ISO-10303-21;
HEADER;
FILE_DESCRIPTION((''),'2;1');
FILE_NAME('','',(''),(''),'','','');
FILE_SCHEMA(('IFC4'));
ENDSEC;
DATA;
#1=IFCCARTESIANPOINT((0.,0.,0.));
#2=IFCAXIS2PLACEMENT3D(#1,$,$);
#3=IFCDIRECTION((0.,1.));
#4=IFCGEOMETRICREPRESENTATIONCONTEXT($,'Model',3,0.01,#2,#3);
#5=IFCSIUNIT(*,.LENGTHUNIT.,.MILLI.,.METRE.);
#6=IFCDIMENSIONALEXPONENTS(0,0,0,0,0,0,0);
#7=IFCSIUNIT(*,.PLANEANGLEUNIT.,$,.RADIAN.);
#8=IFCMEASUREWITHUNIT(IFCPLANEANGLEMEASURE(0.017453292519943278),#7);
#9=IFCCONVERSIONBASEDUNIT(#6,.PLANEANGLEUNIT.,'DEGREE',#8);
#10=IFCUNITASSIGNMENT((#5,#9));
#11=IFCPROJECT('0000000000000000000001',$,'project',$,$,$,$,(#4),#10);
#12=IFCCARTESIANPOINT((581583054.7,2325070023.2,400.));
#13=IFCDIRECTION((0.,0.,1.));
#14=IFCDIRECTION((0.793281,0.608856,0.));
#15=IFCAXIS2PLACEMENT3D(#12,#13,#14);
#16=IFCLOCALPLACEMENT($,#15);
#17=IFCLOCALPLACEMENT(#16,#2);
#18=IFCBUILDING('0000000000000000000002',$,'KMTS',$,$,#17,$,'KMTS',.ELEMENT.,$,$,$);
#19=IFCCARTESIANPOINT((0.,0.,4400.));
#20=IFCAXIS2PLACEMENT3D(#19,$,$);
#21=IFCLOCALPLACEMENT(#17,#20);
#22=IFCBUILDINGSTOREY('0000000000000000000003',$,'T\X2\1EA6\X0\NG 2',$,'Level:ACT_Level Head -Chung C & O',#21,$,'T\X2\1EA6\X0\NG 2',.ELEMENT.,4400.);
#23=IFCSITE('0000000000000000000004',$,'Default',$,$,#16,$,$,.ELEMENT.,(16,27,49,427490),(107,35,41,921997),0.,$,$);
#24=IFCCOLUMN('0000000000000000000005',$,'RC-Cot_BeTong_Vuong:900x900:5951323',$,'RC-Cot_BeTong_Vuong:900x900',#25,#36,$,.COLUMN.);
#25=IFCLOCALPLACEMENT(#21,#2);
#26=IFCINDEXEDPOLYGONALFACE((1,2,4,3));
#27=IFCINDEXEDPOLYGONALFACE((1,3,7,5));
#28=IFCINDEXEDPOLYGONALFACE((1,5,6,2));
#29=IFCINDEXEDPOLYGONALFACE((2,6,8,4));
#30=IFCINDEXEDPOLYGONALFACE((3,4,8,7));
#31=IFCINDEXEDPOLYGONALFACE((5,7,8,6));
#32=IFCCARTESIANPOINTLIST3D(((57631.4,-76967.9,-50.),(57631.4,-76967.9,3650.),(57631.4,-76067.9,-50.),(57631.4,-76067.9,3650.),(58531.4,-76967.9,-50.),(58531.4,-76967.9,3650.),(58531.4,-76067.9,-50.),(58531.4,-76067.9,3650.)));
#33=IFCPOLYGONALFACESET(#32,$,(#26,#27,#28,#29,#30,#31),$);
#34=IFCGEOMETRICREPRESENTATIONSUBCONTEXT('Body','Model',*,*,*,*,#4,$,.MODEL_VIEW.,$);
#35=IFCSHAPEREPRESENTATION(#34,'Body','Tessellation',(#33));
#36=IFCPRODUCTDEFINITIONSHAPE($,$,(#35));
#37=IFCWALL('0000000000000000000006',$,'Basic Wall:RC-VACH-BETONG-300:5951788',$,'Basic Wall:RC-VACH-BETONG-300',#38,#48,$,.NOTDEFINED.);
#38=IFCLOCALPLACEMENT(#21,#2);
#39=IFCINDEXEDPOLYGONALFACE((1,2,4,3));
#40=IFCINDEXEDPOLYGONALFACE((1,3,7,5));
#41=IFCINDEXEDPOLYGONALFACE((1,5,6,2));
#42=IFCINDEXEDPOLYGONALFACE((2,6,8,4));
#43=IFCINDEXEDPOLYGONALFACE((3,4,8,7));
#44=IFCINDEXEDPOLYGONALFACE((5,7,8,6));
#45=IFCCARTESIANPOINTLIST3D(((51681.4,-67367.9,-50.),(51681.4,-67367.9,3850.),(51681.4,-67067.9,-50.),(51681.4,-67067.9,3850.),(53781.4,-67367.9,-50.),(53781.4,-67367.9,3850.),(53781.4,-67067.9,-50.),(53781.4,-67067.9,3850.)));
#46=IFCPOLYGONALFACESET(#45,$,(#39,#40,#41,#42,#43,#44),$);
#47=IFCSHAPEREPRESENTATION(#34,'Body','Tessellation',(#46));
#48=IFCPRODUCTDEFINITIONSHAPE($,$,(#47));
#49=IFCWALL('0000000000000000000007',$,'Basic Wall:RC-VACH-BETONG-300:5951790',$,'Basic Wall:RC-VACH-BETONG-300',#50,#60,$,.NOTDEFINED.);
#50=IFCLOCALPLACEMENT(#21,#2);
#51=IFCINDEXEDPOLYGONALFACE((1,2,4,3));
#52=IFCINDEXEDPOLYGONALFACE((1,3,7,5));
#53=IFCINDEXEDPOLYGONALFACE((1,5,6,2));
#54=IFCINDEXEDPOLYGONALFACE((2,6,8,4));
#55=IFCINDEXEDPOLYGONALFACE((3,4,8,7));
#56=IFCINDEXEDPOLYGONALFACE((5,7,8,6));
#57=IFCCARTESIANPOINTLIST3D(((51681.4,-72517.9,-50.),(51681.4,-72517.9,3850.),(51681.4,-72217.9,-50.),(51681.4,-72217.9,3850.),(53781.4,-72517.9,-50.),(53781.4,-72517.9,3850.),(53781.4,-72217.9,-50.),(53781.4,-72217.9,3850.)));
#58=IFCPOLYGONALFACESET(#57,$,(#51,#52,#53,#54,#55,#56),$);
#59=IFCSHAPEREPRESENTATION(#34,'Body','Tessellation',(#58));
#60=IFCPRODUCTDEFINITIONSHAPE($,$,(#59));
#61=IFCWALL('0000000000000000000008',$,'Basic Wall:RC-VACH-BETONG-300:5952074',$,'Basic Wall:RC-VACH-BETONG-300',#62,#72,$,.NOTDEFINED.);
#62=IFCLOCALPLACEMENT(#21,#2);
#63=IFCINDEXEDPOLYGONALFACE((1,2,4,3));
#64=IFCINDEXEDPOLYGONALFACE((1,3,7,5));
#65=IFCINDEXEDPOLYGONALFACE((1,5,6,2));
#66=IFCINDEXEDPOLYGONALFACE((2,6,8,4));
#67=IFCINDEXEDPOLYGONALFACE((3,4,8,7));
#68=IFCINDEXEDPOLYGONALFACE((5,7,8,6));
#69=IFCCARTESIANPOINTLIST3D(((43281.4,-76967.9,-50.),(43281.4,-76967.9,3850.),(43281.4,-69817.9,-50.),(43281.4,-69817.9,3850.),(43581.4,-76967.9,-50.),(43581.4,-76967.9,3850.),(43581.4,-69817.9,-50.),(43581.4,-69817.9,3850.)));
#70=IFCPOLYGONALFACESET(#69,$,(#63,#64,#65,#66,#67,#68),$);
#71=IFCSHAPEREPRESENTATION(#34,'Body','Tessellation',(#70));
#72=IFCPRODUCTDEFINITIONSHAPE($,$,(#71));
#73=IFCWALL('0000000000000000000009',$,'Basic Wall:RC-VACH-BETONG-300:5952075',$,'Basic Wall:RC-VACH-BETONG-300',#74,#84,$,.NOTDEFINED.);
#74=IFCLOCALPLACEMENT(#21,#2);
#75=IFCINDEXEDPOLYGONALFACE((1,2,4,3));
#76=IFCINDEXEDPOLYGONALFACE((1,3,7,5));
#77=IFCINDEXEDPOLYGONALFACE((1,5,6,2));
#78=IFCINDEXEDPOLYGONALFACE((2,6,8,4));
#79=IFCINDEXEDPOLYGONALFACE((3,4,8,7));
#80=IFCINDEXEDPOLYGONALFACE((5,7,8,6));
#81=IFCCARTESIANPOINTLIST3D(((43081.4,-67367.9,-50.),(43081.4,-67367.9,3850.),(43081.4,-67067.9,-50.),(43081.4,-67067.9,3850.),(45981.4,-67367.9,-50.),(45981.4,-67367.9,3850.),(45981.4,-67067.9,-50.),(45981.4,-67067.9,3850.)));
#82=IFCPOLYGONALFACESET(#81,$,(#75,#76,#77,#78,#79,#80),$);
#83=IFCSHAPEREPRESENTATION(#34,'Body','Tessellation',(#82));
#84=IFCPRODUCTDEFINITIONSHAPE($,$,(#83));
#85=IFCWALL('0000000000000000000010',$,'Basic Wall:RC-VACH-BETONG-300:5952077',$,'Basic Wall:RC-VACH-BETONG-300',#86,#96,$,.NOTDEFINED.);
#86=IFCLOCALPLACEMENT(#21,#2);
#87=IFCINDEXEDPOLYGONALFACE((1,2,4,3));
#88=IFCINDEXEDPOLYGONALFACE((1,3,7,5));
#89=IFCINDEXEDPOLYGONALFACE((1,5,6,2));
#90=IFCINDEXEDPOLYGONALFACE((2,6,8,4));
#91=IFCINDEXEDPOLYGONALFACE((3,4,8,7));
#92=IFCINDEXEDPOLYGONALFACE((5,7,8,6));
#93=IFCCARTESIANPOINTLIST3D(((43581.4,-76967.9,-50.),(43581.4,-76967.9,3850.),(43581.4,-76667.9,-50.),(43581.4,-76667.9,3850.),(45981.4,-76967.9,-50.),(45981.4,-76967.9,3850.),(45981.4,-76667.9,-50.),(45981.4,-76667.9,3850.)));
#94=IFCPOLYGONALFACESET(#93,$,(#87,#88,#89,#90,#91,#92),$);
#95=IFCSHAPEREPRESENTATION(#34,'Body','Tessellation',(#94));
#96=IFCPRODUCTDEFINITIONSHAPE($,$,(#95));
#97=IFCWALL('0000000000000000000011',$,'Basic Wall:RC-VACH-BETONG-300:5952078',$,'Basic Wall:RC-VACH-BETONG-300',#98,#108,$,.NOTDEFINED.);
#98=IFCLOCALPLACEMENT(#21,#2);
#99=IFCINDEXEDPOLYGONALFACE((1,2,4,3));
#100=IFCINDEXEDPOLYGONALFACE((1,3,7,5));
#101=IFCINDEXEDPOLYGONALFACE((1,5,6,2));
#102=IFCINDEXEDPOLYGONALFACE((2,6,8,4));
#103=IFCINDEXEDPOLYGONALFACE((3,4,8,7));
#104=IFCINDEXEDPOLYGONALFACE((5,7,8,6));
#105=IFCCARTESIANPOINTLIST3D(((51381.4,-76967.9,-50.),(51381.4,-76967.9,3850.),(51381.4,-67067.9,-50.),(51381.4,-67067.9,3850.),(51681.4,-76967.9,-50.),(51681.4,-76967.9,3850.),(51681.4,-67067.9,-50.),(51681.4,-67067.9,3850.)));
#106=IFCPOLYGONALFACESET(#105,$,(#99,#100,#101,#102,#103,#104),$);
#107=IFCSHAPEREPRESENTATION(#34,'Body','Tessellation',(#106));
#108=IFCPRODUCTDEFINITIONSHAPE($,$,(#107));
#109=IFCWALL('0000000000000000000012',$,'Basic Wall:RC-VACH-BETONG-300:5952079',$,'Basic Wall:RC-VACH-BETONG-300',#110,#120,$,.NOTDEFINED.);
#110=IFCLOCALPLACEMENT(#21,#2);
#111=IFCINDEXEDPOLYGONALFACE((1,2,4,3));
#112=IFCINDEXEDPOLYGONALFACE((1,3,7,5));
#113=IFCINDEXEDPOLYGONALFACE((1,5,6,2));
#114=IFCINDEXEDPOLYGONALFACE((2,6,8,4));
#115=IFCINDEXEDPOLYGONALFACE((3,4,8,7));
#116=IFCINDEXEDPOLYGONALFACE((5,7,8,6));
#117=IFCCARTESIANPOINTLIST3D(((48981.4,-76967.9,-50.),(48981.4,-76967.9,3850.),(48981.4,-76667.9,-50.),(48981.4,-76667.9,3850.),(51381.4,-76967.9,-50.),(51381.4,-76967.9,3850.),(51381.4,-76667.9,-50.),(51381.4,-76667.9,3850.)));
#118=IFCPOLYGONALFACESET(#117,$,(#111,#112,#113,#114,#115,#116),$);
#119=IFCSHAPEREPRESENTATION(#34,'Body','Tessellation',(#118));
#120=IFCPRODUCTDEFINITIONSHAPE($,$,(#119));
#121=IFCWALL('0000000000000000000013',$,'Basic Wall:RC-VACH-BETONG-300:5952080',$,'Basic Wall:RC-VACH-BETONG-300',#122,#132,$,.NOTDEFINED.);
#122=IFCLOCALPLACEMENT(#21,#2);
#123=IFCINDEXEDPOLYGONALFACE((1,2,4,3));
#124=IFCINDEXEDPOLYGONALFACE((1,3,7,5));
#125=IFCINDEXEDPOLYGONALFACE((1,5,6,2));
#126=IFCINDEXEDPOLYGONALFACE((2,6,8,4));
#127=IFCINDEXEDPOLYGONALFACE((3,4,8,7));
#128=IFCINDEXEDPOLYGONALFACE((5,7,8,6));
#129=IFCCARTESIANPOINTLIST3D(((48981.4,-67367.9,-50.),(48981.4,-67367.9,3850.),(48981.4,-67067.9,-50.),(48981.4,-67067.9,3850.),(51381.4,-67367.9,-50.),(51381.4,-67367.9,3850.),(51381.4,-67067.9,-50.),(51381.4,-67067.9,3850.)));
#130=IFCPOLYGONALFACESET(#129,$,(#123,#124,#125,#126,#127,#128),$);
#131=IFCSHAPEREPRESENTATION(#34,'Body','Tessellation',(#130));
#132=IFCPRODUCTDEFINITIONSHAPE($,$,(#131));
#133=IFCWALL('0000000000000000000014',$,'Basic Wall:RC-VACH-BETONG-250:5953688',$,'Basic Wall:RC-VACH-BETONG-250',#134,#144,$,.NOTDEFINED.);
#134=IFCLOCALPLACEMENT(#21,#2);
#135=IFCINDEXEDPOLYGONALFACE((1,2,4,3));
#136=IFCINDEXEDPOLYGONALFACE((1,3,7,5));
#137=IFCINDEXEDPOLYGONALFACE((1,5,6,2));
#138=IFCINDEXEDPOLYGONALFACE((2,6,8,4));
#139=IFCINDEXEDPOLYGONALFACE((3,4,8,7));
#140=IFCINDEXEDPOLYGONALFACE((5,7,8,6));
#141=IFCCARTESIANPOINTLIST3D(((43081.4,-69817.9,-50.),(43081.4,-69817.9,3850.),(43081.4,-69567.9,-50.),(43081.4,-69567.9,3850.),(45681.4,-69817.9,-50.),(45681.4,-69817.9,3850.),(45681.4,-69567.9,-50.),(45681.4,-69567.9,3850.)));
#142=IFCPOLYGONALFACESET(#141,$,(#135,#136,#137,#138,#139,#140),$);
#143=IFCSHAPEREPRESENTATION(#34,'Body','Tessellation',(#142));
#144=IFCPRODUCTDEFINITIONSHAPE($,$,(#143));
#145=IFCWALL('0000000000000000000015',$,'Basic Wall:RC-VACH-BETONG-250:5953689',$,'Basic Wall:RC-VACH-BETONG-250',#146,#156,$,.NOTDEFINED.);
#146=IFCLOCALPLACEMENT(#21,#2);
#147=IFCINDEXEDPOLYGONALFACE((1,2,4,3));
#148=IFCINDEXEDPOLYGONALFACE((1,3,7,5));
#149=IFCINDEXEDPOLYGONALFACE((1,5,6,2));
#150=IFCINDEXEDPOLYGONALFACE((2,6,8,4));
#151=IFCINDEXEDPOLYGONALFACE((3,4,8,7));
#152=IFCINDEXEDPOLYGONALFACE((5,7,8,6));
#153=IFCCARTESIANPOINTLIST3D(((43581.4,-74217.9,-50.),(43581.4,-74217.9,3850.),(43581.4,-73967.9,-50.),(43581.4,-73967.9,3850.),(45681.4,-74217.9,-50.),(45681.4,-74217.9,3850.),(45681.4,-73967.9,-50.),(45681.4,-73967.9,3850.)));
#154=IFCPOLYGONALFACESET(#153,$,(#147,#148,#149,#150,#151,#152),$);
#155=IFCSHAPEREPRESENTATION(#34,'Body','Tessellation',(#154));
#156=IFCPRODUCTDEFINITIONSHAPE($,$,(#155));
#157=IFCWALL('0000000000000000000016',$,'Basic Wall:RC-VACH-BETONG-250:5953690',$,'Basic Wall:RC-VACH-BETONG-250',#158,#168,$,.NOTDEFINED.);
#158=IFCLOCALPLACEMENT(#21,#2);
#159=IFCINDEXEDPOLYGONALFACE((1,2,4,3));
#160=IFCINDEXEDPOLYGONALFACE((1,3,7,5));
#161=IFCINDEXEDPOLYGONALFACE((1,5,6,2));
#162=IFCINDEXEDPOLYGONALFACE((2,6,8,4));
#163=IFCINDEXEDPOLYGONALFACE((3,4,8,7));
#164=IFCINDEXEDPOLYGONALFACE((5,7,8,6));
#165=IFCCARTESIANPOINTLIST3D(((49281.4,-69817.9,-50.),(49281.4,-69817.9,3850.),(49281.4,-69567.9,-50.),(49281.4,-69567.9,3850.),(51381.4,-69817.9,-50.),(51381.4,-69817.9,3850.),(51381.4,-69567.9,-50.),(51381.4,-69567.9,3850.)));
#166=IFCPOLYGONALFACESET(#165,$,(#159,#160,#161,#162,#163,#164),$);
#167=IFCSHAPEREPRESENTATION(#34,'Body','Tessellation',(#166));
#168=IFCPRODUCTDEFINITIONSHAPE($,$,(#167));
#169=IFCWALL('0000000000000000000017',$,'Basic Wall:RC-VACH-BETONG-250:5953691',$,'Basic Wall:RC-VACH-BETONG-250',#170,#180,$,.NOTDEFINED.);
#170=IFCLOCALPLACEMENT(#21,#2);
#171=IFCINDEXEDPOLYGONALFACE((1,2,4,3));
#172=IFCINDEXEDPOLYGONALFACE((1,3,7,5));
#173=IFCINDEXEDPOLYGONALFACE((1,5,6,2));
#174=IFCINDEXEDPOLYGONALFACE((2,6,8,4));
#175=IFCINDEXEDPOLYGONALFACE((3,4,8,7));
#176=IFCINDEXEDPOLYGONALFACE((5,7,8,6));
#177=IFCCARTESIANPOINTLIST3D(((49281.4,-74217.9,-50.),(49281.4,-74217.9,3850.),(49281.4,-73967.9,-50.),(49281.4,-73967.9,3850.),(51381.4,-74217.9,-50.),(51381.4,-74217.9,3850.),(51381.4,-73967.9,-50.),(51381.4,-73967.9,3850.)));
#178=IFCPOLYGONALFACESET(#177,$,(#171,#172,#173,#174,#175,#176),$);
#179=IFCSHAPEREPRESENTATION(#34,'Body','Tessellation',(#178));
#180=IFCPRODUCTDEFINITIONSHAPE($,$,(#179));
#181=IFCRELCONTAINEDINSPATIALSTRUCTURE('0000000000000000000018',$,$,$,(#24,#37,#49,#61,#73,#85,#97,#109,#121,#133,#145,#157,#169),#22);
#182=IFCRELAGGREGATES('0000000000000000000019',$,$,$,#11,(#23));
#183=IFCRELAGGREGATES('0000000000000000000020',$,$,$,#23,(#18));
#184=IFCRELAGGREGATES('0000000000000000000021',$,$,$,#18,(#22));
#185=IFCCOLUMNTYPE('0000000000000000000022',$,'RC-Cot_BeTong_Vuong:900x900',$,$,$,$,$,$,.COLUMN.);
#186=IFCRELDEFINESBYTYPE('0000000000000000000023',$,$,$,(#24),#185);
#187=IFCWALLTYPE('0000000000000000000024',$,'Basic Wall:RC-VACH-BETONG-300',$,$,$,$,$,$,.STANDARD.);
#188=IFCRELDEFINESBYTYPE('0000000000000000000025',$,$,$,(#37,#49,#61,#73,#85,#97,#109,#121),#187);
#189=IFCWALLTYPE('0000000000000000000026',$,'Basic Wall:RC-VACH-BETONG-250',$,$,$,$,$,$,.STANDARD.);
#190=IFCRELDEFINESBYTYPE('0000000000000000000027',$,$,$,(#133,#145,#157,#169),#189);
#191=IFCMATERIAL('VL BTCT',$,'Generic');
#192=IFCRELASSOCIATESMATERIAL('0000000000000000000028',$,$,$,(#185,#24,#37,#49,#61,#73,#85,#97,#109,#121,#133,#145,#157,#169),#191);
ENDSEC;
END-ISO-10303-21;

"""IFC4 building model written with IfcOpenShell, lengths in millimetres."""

from ifc_helpers import new_model, entity, si_unit, converted_unit, direction, frame, origin, place, context, subcontext, project, spatial, indexed_curve, outline, extrude, source, transform, mapped, material, type_object, type_shapes, element, save


model = new_model("IFC4")

# Units and contexts
model_context = context("Model", 3, precision=0.01, world=origin(), true_north=direction((0.0, 1.0)))
body_context = subcontext(model_context, "Body", "Model", "MODEL_VIEW")
ifc_project = project(units=[si_unit("LENGTHUNIT", "METRE", prefix="MILLI"), converted_unit("PLANEANGLEUNIT", "DEGREE", entity("IfcPlaneAngleMeasure", 0.017453292519943278), si_unit("PLANEANGLEUNIT", "RADIAN"), dimensions=[0, 0, 0, 0, 0, 0, 0])], contexts=[model_context])

# Site, building, storey
site_placement = place(None, frame((581583054.7, 2325070023.2, 400.0), z_axis=(0.0, 0.0, 1.0), x_axis=(0.793281, 0.608856, 0.0)))
site = spatial("IfcSite", under=ifc_project, at=site_placement, Name="Default", CompositionType="ELEMENT", RefLatitude=(16, 27, 49, 427490), RefLongitude=(107, 35, 41, 921997), RefElevation=0.0)
building_placement = place(site_placement, origin())
building = spatial("IfcBuilding", under=site, at=building_placement, Name="KMTS", LongName="KMTS", CompositionType="ELEMENT")
storey_placement = place(building_placement, frame((0.0, 0.0, 4400.0)))
storey = spatial("IfcBuildingStorey", under=building, at=storey_placement, Name="TẦNG 2", ObjectType="Level:ACT_Level Head -Chung C & O", LongName="TẦNG 2", CompositionType="ELEMENT", Elevation=4400.0)

# Column
ifc_material_1 = material(Name="VL BTCT", Category="Generic")
column_type_1 = type_object("IfcColumnType", Name="RC-Cot_BeTong_Vuong:900x900", PredefinedType="COLUMN", material=ifc_material_1)
shared_shape_1 = source(origin(), body_context, "Body", "SweptSolid", [
    extrude(outline(indexed_curve([(-450.0, -450.0), (450.0, -450.0), (450.0, 450.0), (-450.0, 450.0), (-450.0, -450.0)], self_intersect=False)), frame((58081.4, -76517.9, 4350.0), z_axis=(0.0, 0.0, 1.0), x_axis=(-1.0, 0.0, 0.0)), (0.0, 0.0, 1.0), 3700.0),
])
type_shapes(column_type_1, [shared_shape_1])
column_1_placement = place(storey_placement, frame((0.0, 0.0, -4400.0)))
element("IfcColumn", 1, at=column_1_placement, inside=storey, type_object=column_type_1, material=ifc_material_1, Name="RC-Cot_BeTong_Vuong:900x900:5951323", ObjectType="RC-Cot_BeTong_Vuong:900x900", PredefinedType="COLUMN", context=body_context, shape_type="MappedRepresentation", body=[
    mapped(shared_shape_1, transform((0.0, 0.0, 0.0), scale=1.0)),
])

# Walls
wall_type_1 = type_object("IfcWallType", Name="Basic Wall:RC-VACH-BETONG-300", PredefinedType="STANDARD")
wall_1_placement = place(storey_placement, frame((53781.4, -67217.9, -50.0), z_axis=(0.0, 0.0, 1.0), x_axis=(-1.0, 0.0, 0.0)))
element("IfcWall", 2, at=wall_1_placement, inside=storey, type_object=wall_type_1, material=ifc_material_1, Name="Basic Wall:RC-VACH-BETONG-300:5951788", ObjectType="Basic Wall:RC-VACH-BETONG-300", PredefinedType="NOTDEFINED", context=body_context, shape_type="SweptSolid", body=[
    extrude(outline(indexed_curve([(2100.0, 150.0), (0.0, 150.0), (0.0, -150.0), (2100.0, -150.0), (2100.0, 150.0)], self_intersect=False)), origin(), (0.0, 0.0, 1.0), 3900.0),
])
wall_2_placement = place(storey_placement, frame((53781.4, -72367.9, -50.0), z_axis=(0.0, 0.0, 1.0), x_axis=(-1.0, 0.0, 0.0)))
element("IfcWall", 3, at=wall_2_placement, inside=storey, type_object=wall_type_1, material=ifc_material_1, Name="Basic Wall:RC-VACH-BETONG-300:5951790", ObjectType="Basic Wall:RC-VACH-BETONG-300", PredefinedType="NOTDEFINED", context=body_context, shape_type="SweptSolid", body=[
    extrude(outline(indexed_curve([(2100.0, 150.0), (0.0, 150.0), (0.0, -150.0), (2100.0, -150.0), (2100.0, 150.0)], self_intersect=False)), origin(), (0.0, 0.0, 1.0), 3900.0),
])
wall_3_placement = place(storey_placement, frame((43431.4, -69817.9, -50.0), z_axis=(0.0, 0.0, 1.0), x_axis=(0.0, -1.0, 0.0)))
element("IfcWall", 4, at=wall_3_placement, inside=storey, type_object=wall_type_1, material=ifc_material_1, Name="Basic Wall:RC-VACH-BETONG-300:5952074", ObjectType="Basic Wall:RC-VACH-BETONG-300", PredefinedType="NOTDEFINED", context=body_context, shape_type="SweptSolid", body=[
    extrude(outline(indexed_curve([(7150.0, 150.0), (0.0, 150.0), (0.0, -150.0), (7150.0, -150.0), (7150.0, 150.0)], self_intersect=False)), origin(), (0.0, 0.0, 1.0), 3900.0),
])
wall_4_placement = place(storey_placement, frame((45981.4, -67217.9, -50.0), z_axis=(0.0, 0.0, 1.0), x_axis=(-1.0, 0.0, 0.0)))
element("IfcWall", 5, at=wall_4_placement, inside=storey, type_object=wall_type_1, material=ifc_material_1, Name="Basic Wall:RC-VACH-BETONG-300:5952075", ObjectType="Basic Wall:RC-VACH-BETONG-300", PredefinedType="NOTDEFINED", context=body_context, shape_type="SweptSolid", body=[
    extrude(outline(indexed_curve([(2900.0, 150.0), (0.0, 150.0), (0.0, -150.0), (2900.0, -150.0), (2900.0, 150.0)], self_intersect=False)), origin(), (0.0, 0.0, 1.0), 3900.0),
])
wall_5_placement = place(storey_placement, frame((45981.4, -76817.9, -50.0), z_axis=(0.0, 0.0, 1.0), x_axis=(-1.0, 0.0, 0.0)))
element("IfcWall", 6, at=wall_5_placement, inside=storey, type_object=wall_type_1, material=ifc_material_1, Name="Basic Wall:RC-VACH-BETONG-300:5952077", ObjectType="Basic Wall:RC-VACH-BETONG-300", PredefinedType="NOTDEFINED", context=body_context, shape_type="SweptSolid", body=[
    extrude(outline(indexed_curve([(2400.0, 150.0), (0.0, 150.0), (0.0, -150.0), (2400.0, -150.0), (2400.0, 150.0)], self_intersect=False)), origin(), (0.0, 0.0, 1.0), 3900.0),
])
wall_6_placement = place(storey_placement, frame((51531.4, -67067.9, -50.0), z_axis=(0.0, 0.0, 1.0), x_axis=(0.0, -1.0, 0.0)))
element("IfcWall", 7, at=wall_6_placement, inside=storey, type_object=wall_type_1, material=ifc_material_1, Name="Basic Wall:RC-VACH-BETONG-300:5952078", ObjectType="Basic Wall:RC-VACH-BETONG-300", PredefinedType="NOTDEFINED", context=body_context, shape_type="SweptSolid", body=[
    extrude(outline(indexed_curve([(9900.0, 150.0), (0.0, 150.0), (0.0, -150.0), (9900.0, -150.0), (9900.0, 150.0)], self_intersect=False)), origin(), (0.0, 0.0, 1.0), 3900.0),
])
wall_7_placement = place(storey_placement, frame((51381.4, -76817.9, -50.0), z_axis=(0.0, 0.0, 1.0), x_axis=(-1.0, 0.0, 0.0)))
element("IfcWall", 8, at=wall_7_placement, inside=storey, type_object=wall_type_1, material=ifc_material_1, Name="Basic Wall:RC-VACH-BETONG-300:5952079", ObjectType="Basic Wall:RC-VACH-BETONG-300", PredefinedType="NOTDEFINED", context=body_context, shape_type="SweptSolid", body=[
    extrude(outline(indexed_curve([(2400.0, 150.0), (0.0, 150.0), (0.0, -150.0), (2400.0, -150.0), (2400.0, 150.0)], self_intersect=False)), origin(), (0.0, 0.0, 1.0), 3900.0),
])
wall_8_placement = place(storey_placement, frame((51381.4, -67217.9, -50.0), z_axis=(0.0, 0.0, 1.0), x_axis=(-1.0, 0.0, 0.0)))
element("IfcWall", 9, at=wall_8_placement, inside=storey, type_object=wall_type_1, material=ifc_material_1, Name="Basic Wall:RC-VACH-BETONG-300:5952080", ObjectType="Basic Wall:RC-VACH-BETONG-300", PredefinedType="NOTDEFINED", context=body_context, shape_type="SweptSolid", body=[
    extrude(outline(indexed_curve([(2400.0, 150.0), (0.0, 150.0), (0.0, -150.0), (2400.0, -150.0), (2400.0, 150.0)], self_intersect=False)), origin(), (0.0, 0.0, 1.0), 3900.0),
])
wall_type_2 = type_object("IfcWallType", Name="Basic Wall:RC-VACH-BETONG-250", PredefinedType="STANDARD")
wall_9_placement = place(storey_placement, frame((45681.4, -69692.9, -50.0), z_axis=(0.0, 0.0, 1.0), x_axis=(-1.0, 0.0, 0.0)))
element("IfcWall", 10, at=wall_9_placement, inside=storey, type_object=wall_type_2, material=ifc_material_1, Name="Basic Wall:RC-VACH-BETONG-250:5953688", ObjectType="Basic Wall:RC-VACH-BETONG-250", PredefinedType="NOTDEFINED", context=body_context, shape_type="SweptSolid", body=[
    extrude(outline(indexed_curve([(2600.0, 125.0), (0.0, 125.0), (0.0, -125.0), (2600.0, -125.0), (2600.0, 125.0)], self_intersect=False)), origin(), (0.0, 0.0, 1.0), 3900.0),
])
wall_10_placement = place(storey_placement, frame((45681.4, -74092.9, -50.0), z_axis=(0.0, 0.0, 1.0), x_axis=(-1.0, 0.0, 0.0)))
element("IfcWall", 11, at=wall_10_placement, inside=storey, type_object=wall_type_2, material=ifc_material_1, Name="Basic Wall:RC-VACH-BETONG-250:5953689", ObjectType="Basic Wall:RC-VACH-BETONG-250", PredefinedType="NOTDEFINED", context=body_context, shape_type="SweptSolid", body=[
    extrude(outline(indexed_curve([(2100.0, 125.0), (0.0, 125.0), (0.0, -125.0), (2100.0, -125.0), (2100.0, 125.0)], self_intersect=False)), origin(), (0.0, 0.0, 1.0), 3900.0),
])
for number, where, z_axis, x_axis, name in (
    (12, (51381.4, -69692.9, -50.0), (0.0, 0.0, 1.0), (-1.0, 0.0, 0.0), "Basic Wall:RC-VACH-BETONG-250:5953690"),
    (13, (51381.4, -74092.9, -50.0), (0.0, 0.0, 1.0), (-1.0, 0.0, 0.0), "Basic Wall:RC-VACH-BETONG-250:5953691"),
):
    element("IfcWall", number, at=place(storey_placement, frame(where, z_axis=z_axis, x_axis=x_axis)), inside=storey, type_object=wall_type_2, material=ifc_material_1, Name=name, ObjectType="Basic Wall:RC-VACH-BETONG-250", PredefinedType="NOTDEFINED", context=body_context, shape_type="SweptSolid", body=[
        extrude(outline(indexed_curve([(2100.0, 125.0), (0.0, 125.0), (0.0, -125.0), (2100.0, -125.0), (2100.0, 125.0)], self_intersect=False)), origin(), (0.0, 0.0, 1.0), 3900.0),
    ])

save(model, "model.ifc")
